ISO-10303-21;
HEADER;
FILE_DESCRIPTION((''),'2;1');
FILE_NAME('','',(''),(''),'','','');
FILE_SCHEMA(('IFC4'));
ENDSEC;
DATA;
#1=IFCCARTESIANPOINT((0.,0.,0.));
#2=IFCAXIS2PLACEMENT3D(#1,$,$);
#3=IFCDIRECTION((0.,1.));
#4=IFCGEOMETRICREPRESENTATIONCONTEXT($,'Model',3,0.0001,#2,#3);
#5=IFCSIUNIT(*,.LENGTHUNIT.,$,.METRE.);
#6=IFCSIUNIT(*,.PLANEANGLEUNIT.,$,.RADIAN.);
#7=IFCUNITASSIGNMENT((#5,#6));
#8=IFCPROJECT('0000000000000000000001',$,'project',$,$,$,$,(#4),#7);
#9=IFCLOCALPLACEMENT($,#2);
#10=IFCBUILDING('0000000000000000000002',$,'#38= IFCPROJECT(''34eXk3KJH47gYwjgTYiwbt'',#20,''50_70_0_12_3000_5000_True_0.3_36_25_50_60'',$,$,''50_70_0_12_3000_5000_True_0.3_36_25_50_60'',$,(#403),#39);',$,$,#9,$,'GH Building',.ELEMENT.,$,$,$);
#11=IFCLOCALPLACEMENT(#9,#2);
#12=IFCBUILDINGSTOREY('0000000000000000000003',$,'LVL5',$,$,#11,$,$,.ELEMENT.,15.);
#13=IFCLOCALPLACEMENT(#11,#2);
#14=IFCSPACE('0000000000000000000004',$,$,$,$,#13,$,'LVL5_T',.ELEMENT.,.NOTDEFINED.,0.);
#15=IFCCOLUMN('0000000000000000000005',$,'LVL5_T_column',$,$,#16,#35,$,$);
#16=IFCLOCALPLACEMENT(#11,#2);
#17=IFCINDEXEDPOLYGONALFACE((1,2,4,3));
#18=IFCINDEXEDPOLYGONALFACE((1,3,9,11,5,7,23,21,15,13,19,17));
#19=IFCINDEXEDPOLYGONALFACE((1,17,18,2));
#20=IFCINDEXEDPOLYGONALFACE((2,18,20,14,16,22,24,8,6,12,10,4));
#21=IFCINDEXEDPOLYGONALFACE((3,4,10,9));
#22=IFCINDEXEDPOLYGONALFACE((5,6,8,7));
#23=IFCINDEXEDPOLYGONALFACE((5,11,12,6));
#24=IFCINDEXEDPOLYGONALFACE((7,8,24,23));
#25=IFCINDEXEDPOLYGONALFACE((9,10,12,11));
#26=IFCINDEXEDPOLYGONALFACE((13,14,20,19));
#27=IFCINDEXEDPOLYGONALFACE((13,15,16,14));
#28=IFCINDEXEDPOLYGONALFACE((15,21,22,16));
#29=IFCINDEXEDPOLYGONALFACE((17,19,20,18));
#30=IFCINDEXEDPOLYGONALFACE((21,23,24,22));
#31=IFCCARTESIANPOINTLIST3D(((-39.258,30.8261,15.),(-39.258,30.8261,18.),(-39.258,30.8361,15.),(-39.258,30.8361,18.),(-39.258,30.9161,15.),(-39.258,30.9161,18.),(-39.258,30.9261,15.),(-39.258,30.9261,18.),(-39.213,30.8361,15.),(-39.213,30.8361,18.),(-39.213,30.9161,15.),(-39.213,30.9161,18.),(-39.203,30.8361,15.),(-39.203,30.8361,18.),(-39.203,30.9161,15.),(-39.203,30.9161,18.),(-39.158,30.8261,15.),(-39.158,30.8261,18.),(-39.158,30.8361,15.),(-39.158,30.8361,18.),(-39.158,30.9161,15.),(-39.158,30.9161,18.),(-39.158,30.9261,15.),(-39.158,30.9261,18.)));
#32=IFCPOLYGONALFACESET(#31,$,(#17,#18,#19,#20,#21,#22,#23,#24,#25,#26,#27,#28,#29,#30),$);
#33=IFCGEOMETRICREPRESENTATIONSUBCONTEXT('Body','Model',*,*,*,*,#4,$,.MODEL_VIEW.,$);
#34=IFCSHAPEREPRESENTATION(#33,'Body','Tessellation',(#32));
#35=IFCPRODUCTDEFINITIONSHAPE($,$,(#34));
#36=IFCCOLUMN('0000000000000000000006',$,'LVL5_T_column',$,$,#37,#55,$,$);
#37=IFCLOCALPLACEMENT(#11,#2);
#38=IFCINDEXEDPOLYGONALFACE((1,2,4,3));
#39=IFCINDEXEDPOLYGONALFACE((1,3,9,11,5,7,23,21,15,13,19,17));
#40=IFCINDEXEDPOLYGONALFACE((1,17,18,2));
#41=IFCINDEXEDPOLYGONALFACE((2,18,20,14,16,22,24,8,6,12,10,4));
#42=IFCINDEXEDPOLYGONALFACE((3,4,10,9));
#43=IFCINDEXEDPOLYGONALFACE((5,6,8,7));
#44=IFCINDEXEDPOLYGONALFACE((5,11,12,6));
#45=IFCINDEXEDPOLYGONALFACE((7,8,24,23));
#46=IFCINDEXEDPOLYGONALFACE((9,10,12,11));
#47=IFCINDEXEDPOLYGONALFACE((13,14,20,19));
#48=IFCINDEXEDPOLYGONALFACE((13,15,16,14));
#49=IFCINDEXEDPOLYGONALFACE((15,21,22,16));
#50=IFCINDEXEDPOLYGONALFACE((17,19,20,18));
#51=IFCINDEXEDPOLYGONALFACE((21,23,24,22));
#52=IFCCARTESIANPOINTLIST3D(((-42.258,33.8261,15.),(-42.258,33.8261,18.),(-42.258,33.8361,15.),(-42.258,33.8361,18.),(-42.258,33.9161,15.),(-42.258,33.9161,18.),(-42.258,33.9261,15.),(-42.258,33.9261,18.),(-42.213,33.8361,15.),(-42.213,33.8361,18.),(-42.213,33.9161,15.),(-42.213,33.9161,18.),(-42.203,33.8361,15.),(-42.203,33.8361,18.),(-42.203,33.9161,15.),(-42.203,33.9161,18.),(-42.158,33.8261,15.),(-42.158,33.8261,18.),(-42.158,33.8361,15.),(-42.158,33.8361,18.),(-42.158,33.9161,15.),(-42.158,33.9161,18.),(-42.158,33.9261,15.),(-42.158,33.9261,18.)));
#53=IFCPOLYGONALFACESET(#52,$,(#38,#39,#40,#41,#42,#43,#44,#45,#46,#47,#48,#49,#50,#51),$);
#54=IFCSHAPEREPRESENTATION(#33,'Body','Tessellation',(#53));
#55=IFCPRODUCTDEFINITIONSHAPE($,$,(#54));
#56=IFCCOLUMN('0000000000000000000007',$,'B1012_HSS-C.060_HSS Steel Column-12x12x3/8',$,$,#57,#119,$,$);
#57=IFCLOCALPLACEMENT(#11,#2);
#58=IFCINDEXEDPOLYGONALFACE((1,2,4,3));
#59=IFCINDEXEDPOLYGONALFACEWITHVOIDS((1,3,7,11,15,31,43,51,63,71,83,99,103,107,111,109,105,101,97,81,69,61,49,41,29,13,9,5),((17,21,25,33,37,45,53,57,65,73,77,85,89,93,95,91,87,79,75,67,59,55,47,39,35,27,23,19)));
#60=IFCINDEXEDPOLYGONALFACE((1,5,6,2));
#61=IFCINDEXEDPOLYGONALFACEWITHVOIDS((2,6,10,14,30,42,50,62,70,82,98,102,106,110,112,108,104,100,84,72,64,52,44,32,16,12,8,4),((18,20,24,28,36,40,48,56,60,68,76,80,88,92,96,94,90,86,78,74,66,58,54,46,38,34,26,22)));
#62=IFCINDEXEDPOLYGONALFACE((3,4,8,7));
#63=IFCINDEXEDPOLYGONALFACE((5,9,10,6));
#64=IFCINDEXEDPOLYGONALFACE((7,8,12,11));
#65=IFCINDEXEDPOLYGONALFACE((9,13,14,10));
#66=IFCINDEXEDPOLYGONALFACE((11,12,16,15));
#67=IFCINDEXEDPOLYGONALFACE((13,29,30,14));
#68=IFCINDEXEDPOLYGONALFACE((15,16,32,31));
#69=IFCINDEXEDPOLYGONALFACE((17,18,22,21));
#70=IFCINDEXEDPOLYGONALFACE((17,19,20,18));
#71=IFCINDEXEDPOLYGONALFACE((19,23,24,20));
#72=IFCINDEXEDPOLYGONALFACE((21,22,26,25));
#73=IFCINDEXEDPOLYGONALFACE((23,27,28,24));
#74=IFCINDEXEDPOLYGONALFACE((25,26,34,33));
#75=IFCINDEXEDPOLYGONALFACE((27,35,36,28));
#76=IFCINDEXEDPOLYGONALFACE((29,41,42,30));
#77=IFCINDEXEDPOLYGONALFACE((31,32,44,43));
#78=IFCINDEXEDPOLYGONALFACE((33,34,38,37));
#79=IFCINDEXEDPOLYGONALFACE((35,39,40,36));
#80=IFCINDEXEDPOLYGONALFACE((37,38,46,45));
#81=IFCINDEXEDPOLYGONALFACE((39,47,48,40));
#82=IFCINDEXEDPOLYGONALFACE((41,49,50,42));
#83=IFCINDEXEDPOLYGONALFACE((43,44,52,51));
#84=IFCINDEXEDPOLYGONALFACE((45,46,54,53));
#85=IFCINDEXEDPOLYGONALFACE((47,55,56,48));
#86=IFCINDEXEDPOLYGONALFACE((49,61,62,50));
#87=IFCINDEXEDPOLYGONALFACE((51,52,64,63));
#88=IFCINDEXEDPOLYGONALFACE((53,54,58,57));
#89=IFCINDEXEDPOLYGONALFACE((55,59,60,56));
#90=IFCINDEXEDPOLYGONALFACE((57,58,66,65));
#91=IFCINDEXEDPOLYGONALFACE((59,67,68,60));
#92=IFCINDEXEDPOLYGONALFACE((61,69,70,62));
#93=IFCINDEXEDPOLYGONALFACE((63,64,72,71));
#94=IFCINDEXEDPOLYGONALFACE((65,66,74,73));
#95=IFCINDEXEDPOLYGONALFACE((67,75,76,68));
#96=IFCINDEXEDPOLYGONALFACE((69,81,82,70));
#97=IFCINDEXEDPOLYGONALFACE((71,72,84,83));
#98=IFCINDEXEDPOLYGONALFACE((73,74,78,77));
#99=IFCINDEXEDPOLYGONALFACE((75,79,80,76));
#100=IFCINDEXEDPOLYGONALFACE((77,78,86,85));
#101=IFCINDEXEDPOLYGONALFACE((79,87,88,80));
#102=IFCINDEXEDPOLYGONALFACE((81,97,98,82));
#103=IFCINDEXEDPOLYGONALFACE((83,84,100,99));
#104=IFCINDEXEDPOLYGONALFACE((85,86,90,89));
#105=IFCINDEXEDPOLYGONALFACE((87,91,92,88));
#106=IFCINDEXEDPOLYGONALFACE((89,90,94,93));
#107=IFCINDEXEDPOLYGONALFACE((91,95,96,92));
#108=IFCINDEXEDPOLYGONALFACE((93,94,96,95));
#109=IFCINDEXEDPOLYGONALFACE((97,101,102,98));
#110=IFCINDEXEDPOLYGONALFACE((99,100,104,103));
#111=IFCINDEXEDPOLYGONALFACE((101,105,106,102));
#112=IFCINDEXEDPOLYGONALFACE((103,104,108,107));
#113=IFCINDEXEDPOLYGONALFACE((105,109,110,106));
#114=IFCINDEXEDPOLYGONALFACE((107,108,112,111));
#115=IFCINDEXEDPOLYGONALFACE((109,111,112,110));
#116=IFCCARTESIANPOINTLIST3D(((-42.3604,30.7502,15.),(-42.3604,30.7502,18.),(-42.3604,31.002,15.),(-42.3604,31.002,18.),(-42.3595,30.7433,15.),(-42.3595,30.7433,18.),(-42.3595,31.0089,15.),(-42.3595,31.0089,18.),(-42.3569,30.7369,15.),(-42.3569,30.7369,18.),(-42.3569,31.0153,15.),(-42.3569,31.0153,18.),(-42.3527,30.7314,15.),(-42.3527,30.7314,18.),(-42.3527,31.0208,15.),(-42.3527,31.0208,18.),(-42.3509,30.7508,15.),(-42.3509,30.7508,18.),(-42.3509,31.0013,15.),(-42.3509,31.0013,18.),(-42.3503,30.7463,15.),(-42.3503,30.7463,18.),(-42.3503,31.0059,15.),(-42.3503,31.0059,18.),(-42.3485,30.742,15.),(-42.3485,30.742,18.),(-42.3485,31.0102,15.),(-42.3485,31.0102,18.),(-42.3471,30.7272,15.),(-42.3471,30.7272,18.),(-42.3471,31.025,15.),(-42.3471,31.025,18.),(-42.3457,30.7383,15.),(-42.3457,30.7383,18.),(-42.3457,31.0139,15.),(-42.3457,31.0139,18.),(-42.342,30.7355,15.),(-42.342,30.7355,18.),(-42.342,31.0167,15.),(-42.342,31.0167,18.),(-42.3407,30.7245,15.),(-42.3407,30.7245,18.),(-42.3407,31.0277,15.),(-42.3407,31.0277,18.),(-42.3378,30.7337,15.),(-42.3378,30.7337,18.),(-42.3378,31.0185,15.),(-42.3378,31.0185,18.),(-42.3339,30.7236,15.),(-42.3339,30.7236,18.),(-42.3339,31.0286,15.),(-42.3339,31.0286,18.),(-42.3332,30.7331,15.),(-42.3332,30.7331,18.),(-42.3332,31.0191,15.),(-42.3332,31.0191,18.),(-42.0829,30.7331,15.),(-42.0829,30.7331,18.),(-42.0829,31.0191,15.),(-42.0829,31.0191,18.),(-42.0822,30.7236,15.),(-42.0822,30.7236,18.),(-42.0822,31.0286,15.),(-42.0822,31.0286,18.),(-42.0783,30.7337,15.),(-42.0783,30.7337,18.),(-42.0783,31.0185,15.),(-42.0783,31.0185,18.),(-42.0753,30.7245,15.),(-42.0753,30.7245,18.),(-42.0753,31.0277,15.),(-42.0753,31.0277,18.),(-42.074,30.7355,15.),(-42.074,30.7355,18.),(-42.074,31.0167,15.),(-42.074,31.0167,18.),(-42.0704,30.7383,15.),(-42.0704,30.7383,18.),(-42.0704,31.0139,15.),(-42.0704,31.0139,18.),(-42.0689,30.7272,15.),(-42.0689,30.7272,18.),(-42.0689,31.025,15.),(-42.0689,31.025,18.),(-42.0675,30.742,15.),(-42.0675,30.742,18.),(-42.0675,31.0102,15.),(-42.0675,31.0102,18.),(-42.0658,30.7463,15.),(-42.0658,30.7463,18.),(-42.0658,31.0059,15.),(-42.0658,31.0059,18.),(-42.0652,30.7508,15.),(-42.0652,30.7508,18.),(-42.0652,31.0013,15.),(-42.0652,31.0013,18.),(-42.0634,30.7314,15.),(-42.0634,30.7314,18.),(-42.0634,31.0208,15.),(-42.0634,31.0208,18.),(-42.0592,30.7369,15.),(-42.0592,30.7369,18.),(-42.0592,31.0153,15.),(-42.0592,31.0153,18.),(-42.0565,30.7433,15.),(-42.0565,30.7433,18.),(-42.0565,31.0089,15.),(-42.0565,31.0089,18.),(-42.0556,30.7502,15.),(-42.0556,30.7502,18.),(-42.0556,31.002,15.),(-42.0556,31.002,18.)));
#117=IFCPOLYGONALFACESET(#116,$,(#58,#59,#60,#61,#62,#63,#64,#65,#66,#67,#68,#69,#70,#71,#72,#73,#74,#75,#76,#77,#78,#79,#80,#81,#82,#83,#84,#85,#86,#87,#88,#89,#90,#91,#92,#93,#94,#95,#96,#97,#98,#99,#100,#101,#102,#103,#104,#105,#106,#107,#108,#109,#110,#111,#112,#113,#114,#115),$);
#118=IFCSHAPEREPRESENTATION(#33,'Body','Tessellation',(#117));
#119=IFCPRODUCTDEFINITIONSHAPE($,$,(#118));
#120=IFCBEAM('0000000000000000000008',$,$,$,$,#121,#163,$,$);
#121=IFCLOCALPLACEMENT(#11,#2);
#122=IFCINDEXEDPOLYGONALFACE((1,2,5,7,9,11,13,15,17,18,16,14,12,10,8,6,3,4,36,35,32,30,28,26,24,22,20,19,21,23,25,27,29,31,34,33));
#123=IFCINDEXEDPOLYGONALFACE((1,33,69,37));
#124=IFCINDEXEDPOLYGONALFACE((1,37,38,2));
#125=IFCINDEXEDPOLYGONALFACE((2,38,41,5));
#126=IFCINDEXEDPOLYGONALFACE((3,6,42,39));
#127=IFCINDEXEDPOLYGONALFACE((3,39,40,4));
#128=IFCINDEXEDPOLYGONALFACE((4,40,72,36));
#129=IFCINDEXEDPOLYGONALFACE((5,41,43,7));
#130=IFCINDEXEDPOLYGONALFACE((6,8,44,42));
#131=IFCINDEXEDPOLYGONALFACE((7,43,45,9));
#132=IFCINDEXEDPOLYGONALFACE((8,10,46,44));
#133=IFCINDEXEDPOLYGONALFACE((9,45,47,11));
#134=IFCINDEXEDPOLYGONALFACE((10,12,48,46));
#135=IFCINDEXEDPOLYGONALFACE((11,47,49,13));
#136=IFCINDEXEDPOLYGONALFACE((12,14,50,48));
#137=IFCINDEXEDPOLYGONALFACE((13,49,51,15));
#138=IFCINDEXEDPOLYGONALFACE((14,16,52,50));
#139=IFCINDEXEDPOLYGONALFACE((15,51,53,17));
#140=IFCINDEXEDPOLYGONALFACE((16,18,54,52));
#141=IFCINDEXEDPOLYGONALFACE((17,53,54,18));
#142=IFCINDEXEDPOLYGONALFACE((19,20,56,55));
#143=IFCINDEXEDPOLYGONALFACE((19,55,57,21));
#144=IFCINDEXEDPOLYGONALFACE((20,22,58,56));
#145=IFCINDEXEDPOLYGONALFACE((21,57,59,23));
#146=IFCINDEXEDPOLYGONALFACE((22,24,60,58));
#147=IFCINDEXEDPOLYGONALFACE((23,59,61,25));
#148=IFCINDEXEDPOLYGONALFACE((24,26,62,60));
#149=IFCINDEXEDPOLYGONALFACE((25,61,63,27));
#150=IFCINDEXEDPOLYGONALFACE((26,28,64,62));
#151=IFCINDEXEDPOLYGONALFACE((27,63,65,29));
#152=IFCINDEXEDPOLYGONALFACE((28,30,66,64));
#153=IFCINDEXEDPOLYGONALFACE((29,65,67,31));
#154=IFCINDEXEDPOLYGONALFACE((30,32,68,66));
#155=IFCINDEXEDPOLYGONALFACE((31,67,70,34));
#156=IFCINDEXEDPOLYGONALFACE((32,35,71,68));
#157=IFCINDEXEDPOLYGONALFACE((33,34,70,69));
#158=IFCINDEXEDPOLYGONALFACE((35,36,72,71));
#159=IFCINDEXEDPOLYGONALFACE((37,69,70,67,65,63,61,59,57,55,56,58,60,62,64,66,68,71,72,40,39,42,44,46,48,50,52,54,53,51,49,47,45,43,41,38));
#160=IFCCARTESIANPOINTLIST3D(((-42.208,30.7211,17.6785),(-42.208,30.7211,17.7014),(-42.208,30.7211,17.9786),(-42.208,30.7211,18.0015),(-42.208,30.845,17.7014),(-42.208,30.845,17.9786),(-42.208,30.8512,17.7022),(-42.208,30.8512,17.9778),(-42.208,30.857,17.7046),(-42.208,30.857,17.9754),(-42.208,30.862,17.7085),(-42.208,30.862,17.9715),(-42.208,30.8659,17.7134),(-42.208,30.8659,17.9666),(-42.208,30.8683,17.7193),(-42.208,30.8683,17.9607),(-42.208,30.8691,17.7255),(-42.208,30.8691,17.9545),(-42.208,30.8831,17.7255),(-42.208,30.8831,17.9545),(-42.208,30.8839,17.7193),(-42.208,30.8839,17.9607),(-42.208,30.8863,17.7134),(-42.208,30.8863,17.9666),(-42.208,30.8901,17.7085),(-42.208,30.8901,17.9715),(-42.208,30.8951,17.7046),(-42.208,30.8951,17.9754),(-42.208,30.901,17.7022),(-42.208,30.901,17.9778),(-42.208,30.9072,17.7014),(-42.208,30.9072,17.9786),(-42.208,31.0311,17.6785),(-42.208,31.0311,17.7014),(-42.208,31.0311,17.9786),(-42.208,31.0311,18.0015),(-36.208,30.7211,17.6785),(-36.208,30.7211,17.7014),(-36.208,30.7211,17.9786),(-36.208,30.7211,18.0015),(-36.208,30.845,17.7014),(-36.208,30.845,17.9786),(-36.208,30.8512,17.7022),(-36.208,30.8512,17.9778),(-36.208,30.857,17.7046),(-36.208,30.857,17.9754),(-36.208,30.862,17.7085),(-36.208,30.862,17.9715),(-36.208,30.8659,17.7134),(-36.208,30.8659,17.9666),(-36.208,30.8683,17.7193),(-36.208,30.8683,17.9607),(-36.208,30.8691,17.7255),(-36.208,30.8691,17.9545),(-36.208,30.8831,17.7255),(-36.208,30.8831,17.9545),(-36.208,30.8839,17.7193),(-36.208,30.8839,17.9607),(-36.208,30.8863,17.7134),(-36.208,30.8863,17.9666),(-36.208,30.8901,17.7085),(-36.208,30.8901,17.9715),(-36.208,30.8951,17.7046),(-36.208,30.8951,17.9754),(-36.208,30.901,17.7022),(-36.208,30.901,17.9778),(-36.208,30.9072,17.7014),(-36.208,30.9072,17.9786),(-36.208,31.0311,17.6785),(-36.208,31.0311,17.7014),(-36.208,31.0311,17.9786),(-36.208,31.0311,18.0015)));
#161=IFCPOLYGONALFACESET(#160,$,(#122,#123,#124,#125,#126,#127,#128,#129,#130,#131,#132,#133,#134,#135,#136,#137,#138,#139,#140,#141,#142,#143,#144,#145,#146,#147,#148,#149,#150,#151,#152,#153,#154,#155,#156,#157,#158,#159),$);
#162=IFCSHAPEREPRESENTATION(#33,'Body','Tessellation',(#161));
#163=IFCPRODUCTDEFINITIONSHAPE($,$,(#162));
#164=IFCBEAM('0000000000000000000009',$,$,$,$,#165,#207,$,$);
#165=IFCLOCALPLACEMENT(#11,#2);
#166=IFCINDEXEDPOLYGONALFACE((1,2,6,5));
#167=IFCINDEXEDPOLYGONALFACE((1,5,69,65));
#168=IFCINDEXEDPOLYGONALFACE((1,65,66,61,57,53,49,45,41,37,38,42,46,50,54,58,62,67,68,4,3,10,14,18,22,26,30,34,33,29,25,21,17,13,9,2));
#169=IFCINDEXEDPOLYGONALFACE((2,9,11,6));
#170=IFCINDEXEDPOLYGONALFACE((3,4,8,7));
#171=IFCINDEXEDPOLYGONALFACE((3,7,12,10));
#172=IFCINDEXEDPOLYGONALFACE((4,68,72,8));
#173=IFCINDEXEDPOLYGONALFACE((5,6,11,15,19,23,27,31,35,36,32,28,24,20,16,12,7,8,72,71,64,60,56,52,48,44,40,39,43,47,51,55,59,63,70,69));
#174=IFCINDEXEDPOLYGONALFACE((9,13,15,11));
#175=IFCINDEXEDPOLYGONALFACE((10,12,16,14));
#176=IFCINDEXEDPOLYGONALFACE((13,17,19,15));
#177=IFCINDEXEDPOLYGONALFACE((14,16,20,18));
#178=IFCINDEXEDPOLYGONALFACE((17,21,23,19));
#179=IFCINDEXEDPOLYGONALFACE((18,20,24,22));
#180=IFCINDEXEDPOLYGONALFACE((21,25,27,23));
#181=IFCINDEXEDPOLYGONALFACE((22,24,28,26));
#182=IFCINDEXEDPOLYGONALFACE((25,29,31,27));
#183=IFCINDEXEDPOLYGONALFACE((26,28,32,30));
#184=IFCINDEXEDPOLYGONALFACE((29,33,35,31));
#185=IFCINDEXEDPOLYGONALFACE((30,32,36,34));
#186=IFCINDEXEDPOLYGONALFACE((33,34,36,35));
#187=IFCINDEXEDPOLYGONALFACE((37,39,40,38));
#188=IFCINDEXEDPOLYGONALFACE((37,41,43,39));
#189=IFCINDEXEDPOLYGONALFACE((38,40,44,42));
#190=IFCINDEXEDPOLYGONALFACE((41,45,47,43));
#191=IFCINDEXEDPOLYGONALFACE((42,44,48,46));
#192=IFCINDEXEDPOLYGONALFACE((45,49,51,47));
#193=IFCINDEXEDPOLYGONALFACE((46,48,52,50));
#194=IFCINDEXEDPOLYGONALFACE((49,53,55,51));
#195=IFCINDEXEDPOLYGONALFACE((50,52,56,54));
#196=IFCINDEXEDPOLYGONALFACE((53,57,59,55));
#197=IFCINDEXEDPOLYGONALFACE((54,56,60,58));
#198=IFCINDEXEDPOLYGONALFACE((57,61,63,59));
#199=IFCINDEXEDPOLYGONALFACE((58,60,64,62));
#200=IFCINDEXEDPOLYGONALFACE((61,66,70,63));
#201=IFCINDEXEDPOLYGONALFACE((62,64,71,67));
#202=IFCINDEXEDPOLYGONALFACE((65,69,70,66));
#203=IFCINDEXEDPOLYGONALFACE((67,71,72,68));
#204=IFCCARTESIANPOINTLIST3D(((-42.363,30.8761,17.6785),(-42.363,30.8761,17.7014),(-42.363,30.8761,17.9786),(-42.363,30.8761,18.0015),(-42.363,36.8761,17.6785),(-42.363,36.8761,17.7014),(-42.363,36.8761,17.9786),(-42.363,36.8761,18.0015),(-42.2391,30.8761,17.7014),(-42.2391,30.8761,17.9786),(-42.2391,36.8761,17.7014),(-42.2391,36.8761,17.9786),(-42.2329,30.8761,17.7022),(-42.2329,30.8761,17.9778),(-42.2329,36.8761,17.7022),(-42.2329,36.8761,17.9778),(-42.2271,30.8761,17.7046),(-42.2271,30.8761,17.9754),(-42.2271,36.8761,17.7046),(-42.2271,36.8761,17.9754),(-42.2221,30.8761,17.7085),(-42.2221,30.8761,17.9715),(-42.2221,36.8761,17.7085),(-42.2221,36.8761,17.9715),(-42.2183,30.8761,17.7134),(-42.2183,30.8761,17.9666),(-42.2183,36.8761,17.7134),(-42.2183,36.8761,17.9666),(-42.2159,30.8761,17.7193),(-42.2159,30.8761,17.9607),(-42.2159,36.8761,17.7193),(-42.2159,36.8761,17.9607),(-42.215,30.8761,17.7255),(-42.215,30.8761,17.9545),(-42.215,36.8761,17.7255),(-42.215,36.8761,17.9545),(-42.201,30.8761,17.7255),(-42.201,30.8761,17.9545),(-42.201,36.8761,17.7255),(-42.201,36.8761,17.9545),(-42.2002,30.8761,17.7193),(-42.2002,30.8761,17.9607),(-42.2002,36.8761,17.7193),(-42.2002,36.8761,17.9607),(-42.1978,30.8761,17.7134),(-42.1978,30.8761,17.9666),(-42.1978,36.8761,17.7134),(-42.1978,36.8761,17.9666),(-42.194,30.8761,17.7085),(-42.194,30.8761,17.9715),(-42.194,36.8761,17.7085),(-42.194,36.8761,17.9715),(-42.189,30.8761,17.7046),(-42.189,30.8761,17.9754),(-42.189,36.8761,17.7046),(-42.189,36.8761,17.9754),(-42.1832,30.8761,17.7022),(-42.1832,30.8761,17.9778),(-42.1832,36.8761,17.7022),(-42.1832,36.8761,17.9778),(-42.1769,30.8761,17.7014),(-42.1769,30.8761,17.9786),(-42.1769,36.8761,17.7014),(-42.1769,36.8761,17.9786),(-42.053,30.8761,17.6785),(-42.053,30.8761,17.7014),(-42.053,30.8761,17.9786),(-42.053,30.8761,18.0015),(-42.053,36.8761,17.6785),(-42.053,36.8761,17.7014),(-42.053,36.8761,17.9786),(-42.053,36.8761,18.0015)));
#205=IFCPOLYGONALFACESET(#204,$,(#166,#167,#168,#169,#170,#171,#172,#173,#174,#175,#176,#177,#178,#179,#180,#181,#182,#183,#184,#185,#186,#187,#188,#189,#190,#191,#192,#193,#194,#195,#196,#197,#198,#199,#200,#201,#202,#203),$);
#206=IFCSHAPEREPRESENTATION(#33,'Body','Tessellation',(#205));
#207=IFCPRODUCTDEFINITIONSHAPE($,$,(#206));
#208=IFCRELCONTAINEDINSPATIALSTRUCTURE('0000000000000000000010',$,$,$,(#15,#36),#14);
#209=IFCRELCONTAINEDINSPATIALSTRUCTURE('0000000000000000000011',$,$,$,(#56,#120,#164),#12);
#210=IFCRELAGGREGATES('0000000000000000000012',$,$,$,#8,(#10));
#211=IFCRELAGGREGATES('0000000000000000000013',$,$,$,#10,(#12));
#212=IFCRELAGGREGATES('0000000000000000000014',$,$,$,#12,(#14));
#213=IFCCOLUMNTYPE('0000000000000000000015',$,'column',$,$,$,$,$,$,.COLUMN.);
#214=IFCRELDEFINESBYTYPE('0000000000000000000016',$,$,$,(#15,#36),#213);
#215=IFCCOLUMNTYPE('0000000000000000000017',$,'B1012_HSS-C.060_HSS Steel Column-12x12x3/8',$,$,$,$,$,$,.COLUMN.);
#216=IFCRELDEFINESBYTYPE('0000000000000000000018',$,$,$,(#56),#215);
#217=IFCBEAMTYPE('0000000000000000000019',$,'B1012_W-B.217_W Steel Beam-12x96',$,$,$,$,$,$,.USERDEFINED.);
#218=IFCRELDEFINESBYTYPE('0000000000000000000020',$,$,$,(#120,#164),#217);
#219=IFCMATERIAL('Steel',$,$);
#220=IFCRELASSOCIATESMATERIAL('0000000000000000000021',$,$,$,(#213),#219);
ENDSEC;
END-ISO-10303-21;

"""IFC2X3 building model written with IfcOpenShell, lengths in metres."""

from ifc_helpers import new_model, si_unit, direction, frame, origin, origin_2d, place, context, subcontext, project, spatial, hollow_rectangle, i_section, extrude, material, type_object, element, save


model = new_model("IFC2X3")

# Units and contexts
model_context = context("Model", 3, precision=0.0001, world=origin(), true_north=direction((0.0, 1.0)))
body_context = subcontext(model_context, "Body", "Model", "MODEL_VIEW")
ifc_project = project(units=[si_unit("LENGTHUNIT", "METRE"), si_unit("PLANEANGLEUNIT", "RADIAN")], contexts=[model_context])

# Building, storey, space
building_placement = place(None, origin())
building = spatial("IfcBuilding", under=ifc_project, at=building_placement, Name="#38= IFCPROJECT('34eXk3KJH47gYwjgTYiwbt',#20,'50_70_0_12_3000_5000_True_0.3_36_25_50_60',$,$,'50_70_0_12_3000_5000_True_0.3_36_25_50_60',$,(#403),#39);", LongName="GH Building", CompositionType="ELEMENT")
storey_placement = place(building_placement, origin())
storey = spatial("IfcBuildingStorey", under=building, at=storey_placement, Name="LVL5", CompositionType="ELEMENT", Elevation=15.0)
space_1_placement = place(storey_placement, origin())
space_1 = spatial("IfcSpace", under=storey, at=space_1_placement, LongName="LVL5_T", CompositionType="ELEMENT", InteriorOrExteriorSpace="NOTDEFINED", ElevationWithFlooring=0.0)

# Columns
ifc_material_1 = material(Name="Steel")
column_type_1 = type_object("IfcColumnType", Name="column", PredefinedType="COLUMN", material=ifc_material_1)
for number, where, name in (
    (1, (-39.208, 30.8761, 15.0), "LVL5_T_column"),
    (2, (-42.208, 33.8761, 15.0), "LVL5_T_column"),
):
    element("IfcColumn", number, at=place(space_1_placement, frame(where)), inside=space_1, type_object=column_type_1, Name=name, context=body_context, shape_type="SweptSolid", body=[
        extrude(i_section(OverallWidth=0.1, OverallDepth=0.1, WebThickness=0.01, FlangeThickness=0.01, at=origin_2d()), origin(), (0.0, 0.0, 1.0), 3.0),
    ])

# Column
column_type_2 = type_object("IfcColumnType", Name="B1012_HSS-C.060_HSS Steel Column-12x12x3/8", PredefinedType="COLUMN")
column_placement = place(storey_placement, frame((-42.208, 30.8761, 18.0), z_axis=(0.0, 0.0, -1.0), x_axis=(-1.0, 0.0, 0.0)))
element("IfcColumn", 3, at=column_placement, inside=storey, type_object=column_type_2, Name="B1012_HSS-C.060_HSS Steel Column-12x12x3/8", context=body_context, shape_type="SweptSolid", body=[
    extrude(hollow_rectangle(XDim=0.3048, YDim=0.305, WallThickness=0.0095, InnerFilletRadius=0.0177, OuterFilletRadius=0.0266, at=origin_2d()), origin(), (0.0, 0.0, 1.0), 3.0),
])

# Beams
beam_type = type_object("IfcBeamType", Name="B1012_W-B.217_W Steel Beam-12x96", PredefinedType="USERDEFINED")
for number, where, z_axis, x_axis in (
    (4, (-42.208, 30.8761, 17.84), (1.0, 0.0, 0.0), (0.0, 1.0, 0.0)),
    (5, (-42.208, 30.8761, 17.84), (0.0, 1.0, 0.0), (-1.0, 0.0, 0.0)),
):
    element("IfcBeam", number, at=place(storey_placement, frame(where, z_axis=z_axis, x_axis=x_axis)), inside=storey, type_object=beam_type, context=body_context, shape_type="SweptSolid", body=[
        extrude(i_section(OverallWidth=0.31, OverallDepth=0.323, WebThickness=0.014, FlangeThickness=0.0229, FilletRadius=0.0241, at=origin_2d()), origin(), (0.0, 0.0, 1.0), 6.0),
    ])

save(model, "model.ifc")
